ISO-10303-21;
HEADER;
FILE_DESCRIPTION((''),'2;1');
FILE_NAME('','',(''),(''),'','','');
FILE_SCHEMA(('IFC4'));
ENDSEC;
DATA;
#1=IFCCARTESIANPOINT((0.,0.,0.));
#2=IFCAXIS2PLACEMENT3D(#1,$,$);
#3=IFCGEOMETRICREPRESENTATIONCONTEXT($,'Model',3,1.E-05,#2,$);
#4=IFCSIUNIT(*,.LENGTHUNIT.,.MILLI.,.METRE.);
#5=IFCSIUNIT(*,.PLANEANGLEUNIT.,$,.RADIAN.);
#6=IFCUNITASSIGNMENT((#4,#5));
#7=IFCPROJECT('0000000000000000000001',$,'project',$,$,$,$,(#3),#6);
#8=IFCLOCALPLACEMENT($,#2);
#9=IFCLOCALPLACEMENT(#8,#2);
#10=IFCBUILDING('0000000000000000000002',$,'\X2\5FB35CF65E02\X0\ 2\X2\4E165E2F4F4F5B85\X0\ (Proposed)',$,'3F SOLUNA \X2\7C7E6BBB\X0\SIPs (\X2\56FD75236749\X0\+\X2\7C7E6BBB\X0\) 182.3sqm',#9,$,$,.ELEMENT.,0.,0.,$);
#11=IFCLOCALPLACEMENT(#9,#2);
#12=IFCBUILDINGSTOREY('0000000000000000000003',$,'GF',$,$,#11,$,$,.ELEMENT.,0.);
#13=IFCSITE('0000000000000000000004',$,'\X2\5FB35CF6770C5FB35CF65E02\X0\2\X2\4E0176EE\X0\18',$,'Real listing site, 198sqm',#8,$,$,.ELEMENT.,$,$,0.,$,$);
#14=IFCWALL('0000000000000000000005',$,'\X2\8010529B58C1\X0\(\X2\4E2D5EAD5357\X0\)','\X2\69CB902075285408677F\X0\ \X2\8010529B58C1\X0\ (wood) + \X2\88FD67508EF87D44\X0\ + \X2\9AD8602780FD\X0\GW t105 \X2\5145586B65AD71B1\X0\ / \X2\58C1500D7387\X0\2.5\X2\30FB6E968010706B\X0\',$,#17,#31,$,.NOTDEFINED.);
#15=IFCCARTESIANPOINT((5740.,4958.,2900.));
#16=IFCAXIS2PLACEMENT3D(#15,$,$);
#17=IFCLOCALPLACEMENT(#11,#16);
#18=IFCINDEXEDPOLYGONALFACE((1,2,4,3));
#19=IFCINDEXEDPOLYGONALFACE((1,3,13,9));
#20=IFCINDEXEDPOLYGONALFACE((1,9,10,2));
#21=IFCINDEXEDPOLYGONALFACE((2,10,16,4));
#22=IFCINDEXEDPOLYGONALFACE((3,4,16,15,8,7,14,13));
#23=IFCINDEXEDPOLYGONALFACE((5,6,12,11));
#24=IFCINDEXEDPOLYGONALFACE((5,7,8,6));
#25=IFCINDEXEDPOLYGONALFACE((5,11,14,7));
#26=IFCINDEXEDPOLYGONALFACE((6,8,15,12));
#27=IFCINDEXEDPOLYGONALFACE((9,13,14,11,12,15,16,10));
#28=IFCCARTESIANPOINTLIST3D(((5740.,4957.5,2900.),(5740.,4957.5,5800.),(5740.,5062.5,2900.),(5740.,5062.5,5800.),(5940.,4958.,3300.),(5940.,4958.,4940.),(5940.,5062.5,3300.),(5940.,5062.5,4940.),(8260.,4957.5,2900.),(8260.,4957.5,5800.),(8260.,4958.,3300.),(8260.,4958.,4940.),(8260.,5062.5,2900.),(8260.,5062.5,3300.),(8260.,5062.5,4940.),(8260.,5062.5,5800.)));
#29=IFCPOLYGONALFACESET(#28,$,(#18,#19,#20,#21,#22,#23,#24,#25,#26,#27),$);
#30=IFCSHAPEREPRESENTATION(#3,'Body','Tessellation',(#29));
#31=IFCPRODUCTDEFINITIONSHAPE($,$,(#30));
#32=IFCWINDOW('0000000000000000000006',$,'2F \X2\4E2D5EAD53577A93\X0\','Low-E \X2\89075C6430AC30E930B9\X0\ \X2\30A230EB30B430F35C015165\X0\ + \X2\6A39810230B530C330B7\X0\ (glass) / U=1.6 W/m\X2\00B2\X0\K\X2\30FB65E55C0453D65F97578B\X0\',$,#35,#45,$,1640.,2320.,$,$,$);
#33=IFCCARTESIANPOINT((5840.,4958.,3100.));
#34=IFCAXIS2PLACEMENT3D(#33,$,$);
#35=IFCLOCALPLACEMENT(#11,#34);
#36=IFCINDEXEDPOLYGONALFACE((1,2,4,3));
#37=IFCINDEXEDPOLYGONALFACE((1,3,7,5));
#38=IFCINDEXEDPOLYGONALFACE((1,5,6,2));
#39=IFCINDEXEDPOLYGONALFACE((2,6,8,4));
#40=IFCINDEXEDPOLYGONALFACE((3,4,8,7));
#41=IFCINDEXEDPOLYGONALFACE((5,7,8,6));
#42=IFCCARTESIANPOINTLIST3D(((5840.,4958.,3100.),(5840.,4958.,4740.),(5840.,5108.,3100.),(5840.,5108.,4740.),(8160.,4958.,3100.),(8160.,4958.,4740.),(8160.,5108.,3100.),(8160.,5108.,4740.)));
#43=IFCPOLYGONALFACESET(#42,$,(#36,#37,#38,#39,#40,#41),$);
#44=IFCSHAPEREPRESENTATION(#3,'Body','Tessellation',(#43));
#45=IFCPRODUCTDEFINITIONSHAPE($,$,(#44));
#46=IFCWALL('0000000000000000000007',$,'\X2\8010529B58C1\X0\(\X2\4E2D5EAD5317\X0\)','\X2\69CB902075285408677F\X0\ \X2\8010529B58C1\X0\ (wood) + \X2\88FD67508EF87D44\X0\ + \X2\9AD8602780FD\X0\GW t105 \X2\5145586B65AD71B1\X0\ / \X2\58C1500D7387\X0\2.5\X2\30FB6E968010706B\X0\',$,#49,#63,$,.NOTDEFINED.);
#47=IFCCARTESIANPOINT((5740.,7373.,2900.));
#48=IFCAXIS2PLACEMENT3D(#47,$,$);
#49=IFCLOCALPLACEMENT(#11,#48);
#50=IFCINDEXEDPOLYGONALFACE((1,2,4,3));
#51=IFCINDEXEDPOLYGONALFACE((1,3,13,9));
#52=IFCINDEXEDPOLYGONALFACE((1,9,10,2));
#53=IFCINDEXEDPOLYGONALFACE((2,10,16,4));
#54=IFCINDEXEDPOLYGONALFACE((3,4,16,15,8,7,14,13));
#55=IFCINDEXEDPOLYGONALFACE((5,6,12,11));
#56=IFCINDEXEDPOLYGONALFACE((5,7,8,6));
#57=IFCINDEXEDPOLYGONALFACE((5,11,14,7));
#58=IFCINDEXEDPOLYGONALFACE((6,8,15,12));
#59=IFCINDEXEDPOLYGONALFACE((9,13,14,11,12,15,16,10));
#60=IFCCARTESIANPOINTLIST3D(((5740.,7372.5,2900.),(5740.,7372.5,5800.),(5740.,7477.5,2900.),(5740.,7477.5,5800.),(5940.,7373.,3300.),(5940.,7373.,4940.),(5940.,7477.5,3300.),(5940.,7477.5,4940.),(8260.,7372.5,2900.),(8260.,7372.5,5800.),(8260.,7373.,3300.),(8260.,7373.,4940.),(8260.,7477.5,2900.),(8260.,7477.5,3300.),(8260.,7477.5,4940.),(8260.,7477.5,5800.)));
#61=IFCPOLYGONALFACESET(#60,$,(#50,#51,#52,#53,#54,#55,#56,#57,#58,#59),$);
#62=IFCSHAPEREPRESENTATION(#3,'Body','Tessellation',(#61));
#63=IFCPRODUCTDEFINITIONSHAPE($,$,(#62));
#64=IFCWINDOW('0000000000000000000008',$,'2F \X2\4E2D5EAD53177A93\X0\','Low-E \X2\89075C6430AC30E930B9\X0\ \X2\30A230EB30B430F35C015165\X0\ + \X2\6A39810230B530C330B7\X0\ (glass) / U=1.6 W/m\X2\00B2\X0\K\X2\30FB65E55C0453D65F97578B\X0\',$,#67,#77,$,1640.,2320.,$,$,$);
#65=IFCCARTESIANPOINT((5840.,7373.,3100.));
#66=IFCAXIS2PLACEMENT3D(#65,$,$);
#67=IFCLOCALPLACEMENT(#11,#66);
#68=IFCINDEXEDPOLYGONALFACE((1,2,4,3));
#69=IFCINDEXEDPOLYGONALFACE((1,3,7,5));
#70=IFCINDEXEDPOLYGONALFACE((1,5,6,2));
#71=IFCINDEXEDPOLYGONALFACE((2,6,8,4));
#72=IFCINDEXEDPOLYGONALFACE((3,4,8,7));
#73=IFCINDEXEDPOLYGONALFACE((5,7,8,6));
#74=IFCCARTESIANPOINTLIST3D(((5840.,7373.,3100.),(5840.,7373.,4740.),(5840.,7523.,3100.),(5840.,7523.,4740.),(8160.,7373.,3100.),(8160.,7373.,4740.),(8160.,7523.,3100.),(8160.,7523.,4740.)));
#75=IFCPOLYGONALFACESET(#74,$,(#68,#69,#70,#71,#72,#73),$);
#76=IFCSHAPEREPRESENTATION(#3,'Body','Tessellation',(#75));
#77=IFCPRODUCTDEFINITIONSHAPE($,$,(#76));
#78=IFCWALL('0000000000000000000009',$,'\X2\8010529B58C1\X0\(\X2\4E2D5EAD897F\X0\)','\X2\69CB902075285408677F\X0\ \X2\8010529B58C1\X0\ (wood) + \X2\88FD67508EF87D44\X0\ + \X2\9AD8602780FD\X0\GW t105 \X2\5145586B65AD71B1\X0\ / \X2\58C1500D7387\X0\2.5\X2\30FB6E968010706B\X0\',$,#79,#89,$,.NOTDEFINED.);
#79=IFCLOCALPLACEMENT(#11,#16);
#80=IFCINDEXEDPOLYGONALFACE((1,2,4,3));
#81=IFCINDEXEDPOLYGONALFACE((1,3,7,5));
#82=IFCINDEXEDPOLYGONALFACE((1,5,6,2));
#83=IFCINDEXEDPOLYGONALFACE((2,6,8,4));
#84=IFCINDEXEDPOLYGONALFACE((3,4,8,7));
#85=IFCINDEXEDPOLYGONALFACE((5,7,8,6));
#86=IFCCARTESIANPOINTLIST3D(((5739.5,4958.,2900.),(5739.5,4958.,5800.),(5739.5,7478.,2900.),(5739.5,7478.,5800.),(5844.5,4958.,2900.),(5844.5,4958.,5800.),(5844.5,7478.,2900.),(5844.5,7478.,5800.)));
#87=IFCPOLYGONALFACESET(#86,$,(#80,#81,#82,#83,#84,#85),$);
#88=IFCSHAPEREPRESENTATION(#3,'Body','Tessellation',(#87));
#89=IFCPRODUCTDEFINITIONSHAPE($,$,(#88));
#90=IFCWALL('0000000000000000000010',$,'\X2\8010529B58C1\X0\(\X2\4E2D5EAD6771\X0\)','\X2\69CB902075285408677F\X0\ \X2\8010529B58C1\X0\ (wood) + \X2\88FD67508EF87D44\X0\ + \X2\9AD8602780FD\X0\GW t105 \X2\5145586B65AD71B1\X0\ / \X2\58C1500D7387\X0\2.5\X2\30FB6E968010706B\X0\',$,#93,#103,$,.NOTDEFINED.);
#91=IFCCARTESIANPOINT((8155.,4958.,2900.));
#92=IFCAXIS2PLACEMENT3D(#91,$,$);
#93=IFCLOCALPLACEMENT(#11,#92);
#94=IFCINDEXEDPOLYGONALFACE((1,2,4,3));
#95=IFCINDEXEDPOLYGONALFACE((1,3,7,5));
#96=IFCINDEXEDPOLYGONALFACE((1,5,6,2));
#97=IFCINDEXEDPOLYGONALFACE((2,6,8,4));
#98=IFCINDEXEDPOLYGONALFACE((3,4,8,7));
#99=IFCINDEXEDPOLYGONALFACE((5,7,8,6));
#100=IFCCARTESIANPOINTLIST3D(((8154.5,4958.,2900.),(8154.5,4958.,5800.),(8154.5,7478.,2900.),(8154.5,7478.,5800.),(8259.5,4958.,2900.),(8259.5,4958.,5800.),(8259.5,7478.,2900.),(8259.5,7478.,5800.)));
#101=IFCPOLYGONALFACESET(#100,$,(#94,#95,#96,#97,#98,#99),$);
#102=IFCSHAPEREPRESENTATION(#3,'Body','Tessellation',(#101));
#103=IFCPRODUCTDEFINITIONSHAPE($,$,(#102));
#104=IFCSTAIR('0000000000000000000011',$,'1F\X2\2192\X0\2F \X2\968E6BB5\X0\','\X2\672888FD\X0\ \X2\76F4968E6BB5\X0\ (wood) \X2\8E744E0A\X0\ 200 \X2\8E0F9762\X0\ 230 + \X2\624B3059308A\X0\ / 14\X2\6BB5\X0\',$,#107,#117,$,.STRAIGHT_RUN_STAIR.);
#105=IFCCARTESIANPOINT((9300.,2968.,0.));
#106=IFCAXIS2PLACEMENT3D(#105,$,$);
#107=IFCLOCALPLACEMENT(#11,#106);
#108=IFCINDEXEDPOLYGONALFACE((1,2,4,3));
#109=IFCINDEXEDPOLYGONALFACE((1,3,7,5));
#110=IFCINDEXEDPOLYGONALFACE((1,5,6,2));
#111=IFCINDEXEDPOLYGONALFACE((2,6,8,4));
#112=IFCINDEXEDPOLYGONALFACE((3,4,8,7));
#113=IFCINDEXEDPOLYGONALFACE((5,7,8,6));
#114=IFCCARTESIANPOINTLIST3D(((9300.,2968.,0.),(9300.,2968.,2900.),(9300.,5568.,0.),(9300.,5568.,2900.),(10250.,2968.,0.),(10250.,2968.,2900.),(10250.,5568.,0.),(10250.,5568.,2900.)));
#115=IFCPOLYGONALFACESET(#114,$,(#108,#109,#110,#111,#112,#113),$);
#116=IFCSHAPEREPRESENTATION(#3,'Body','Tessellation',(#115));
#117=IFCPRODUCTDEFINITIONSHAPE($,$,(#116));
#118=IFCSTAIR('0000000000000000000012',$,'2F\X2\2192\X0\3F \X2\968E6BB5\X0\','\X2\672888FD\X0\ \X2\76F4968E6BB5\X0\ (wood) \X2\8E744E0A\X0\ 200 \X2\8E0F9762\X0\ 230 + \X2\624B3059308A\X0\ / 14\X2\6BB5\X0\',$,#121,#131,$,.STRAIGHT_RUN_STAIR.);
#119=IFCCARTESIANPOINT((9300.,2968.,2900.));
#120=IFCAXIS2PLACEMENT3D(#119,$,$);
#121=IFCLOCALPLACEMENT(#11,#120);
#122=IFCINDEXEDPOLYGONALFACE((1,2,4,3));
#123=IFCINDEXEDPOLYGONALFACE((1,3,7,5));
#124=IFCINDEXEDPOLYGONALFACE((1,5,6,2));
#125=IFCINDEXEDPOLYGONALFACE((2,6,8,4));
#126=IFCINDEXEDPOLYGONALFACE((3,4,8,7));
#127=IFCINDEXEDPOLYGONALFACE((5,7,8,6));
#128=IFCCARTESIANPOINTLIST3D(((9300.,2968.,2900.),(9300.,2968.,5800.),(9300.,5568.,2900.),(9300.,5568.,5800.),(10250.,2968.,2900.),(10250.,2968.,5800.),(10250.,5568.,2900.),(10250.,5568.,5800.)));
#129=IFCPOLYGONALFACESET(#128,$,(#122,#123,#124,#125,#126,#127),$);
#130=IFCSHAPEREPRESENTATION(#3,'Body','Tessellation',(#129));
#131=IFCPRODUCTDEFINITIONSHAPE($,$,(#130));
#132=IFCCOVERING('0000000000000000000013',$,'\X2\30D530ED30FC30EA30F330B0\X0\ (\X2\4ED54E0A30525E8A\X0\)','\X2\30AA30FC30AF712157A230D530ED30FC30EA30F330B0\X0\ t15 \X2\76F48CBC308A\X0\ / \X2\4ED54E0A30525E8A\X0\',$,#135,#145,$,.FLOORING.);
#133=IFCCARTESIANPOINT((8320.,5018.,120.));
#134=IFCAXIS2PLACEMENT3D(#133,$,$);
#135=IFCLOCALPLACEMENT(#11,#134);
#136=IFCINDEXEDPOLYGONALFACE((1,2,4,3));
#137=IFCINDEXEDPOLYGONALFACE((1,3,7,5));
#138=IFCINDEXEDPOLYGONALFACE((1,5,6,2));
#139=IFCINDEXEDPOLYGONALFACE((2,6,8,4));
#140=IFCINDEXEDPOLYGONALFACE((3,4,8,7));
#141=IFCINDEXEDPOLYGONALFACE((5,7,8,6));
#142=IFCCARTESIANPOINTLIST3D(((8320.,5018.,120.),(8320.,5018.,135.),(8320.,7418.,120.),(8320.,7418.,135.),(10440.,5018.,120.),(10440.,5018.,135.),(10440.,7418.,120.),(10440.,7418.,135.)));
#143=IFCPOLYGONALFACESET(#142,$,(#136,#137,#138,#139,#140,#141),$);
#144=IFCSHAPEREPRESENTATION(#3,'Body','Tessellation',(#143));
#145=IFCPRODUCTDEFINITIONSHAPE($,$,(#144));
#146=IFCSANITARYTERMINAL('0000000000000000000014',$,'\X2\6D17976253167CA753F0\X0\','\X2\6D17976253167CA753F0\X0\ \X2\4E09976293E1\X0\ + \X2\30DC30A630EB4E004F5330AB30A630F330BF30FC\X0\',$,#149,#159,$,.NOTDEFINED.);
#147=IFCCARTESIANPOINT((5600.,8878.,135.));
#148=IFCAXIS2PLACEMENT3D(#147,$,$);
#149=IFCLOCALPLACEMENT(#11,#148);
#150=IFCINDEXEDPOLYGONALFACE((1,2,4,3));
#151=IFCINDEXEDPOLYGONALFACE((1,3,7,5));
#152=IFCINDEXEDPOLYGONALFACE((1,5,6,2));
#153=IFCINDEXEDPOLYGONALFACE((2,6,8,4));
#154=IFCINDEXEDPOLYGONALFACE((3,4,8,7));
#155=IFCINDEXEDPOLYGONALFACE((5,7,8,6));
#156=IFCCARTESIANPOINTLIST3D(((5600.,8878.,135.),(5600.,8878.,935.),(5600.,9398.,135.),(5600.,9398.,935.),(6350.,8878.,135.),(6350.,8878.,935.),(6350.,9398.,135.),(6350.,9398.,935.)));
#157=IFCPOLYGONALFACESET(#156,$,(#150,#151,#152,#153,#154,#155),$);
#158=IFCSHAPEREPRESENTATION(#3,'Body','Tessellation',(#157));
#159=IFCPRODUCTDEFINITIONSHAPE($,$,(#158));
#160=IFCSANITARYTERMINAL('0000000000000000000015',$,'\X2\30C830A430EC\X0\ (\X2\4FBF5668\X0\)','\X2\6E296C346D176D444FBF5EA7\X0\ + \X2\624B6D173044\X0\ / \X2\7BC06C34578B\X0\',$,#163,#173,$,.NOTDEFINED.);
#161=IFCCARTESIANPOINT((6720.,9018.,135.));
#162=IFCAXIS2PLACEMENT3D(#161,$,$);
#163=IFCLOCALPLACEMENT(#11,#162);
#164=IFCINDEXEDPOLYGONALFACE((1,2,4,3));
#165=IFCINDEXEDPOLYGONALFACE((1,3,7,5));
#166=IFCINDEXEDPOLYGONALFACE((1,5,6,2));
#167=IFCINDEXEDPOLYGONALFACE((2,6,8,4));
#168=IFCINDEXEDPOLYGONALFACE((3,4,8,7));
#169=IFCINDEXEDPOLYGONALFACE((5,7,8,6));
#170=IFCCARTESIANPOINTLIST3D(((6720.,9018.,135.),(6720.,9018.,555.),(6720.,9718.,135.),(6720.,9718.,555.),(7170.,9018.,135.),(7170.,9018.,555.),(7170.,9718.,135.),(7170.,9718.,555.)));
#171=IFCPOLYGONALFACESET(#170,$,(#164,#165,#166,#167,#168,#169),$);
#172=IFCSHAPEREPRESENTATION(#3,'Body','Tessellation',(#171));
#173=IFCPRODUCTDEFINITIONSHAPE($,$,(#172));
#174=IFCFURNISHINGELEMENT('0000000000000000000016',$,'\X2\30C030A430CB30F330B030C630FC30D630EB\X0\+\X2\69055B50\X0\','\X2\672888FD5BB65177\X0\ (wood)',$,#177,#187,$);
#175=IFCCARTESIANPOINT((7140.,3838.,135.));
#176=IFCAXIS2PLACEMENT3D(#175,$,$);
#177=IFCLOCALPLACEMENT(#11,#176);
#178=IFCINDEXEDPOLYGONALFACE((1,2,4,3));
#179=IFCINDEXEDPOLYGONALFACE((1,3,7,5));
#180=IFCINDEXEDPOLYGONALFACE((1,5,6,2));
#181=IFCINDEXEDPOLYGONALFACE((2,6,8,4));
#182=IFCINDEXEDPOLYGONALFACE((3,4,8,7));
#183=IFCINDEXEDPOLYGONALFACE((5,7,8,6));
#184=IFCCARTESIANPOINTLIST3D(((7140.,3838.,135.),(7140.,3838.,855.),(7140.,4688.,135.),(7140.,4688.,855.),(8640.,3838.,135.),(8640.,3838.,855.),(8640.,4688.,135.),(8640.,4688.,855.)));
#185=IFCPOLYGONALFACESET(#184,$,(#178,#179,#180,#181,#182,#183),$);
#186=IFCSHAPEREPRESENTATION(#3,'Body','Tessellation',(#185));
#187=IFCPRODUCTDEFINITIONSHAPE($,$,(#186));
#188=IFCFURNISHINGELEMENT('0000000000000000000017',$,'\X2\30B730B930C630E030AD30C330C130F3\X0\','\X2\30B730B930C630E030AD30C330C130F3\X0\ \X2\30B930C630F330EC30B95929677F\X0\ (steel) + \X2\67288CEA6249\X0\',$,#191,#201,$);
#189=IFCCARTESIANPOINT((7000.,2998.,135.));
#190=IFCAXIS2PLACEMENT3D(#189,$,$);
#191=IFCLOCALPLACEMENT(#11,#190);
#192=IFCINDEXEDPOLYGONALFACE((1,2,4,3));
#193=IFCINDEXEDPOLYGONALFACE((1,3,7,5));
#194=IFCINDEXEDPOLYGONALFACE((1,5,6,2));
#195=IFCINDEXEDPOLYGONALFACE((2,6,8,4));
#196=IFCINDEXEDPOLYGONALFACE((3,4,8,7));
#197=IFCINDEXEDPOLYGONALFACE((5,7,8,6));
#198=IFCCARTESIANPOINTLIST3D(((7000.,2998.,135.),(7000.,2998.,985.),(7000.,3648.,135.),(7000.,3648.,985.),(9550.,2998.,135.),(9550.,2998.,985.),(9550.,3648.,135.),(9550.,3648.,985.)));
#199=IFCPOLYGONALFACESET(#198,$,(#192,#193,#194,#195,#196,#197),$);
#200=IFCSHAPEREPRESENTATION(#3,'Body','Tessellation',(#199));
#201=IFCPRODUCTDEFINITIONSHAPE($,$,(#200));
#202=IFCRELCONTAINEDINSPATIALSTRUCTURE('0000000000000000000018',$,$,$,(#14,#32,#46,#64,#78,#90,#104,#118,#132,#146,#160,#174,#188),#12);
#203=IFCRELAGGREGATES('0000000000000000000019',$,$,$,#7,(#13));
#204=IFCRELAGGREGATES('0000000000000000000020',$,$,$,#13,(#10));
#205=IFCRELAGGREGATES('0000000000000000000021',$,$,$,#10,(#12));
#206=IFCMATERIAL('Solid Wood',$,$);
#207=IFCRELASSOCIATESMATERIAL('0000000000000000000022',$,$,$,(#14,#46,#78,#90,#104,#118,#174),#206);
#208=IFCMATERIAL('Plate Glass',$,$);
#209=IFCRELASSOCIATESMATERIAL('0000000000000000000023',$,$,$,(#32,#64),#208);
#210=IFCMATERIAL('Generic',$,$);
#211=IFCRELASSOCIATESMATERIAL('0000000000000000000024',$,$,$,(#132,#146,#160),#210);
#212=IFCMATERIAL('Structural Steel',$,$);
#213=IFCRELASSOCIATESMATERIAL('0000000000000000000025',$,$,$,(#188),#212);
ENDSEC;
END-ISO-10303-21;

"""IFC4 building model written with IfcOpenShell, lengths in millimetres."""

from ifc_helpers import new_model, si_unit, frame, frame_2d, origin, place, context, project, spatial, rectangle, extrude, material, element, fill, save


model = new_model("IFC4")

# Units and contexts
model_context = context("Model", 3, precision=1e-05, world=origin())
ifc_project = project(units=[si_unit("LENGTHUNIT", "METRE", prefix="MILLI"), si_unit("PLANEANGLEUNIT", "RADIAN")], contexts=[model_context])

# Site, building, storey
site_placement = place(None, origin())
site = spatial("IfcSite", under=ifc_project, at=site_placement, Name="徳島県徳島市2丁目18", ObjectType="Real listing site, 198sqm", CompositionType="ELEMENT", RefElevation=0.0)
building_placement = place(site_placement, origin())
building = spatial("IfcBuilding", under=site, at=building_placement, Name="徳島市 2世帯住宅 (Proposed)", ObjectType="3F SOLUNA 籾殻SIPs (国産杉+籾殻) 182.3sqm", CompositionType="ELEMENT", ElevationOfRefHeight=0.0, ElevationOfTerrain=0.0)
storey_placement = place(building_placement, origin())
storey = spatial("IfcBuildingStorey", under=building, at=storey_placement, Name="GF", CompositionType="ELEMENT", Elevation=0.0)

# Shared definitions
ifc_material_1 = material(Name="Solid Wood")

# Shared definitions
ifc_material_2 = material(Name="Plate Glass")

# Walls, openings, windows
wall_1_placement = place(storey_placement, frame((5740.0, 4958.0, 2900.0)))
wall_1 = element("IfcWall", 1, at=wall_1_placement, inside=storey, material=ifc_material_1, Name="耐力壁(中庭南)", Description="構造用合板 耐力壁 (wood) + 製材軸組 + 高性能GW t105 充填断熱 / 壁倍率2.5・準耐火", PredefinedType="NOTDEFINED", context=model_context, shape_type="SweptSolid", body=[
    extrude(rectangle(XDim=2520.0, YDim=105.0, at=frame_2d((1260.0, 52.0))), frame((5740.0, 4958.0, 2900.0)), (0.0, 0.0, 1.0), 2900.0),
])
opening_1_placement = place(storey_placement, frame((5840.0, 4958.0, 3100.0)))
opening_1 = element("IfcOpeningElement", 2, at=opening_1_placement, cuts=wall_1, PredefinedType="NOTDEFINED", context=model_context, shape_type="SweptSolid", body=[
    extrude(rectangle(XDim=2320.0, YDim=150.0, at=frame_2d((1160.0, 75.0))), frame((5840.0, 4958.0, 3100.0)), (0.0, 0.0, 1.0), 1640.0),
])
window_1_placement = place(storey_placement, frame((5840.0, 4958.0, 3100.0)))
window_1 = element("IfcWindow", 3, at=window_1_placement, inside=storey, material=ifc_material_2, Name="2F 中庭南窓", Description="Low-E 複層ガラス アルゴン封入 + 樹脂サッシ (glass) / U=1.6 W/m²K・日射取得型", OverallHeight=1640.0, OverallWidth=2320.0, context=model_context, shape_type="SweptSolid", body=[
    extrude(rectangle(XDim=2320.0, YDim=150.0, at=frame_2d((1160.0, 75.0))), frame((5840.0, 4958.0, 3100.0)), (0.0, 0.0, 1.0), 1640.0),
])
fill(opening_1, window_1)
wall_2_placement = place(storey_placement, frame((5740.0, 7373.0, 2900.0)))
wall_2 = element("IfcWall", 4, at=wall_2_placement, inside=storey, material=ifc_material_1, Name="耐力壁(中庭北)", Description="構造用合板 耐力壁 (wood) + 製材軸組 + 高性能GW t105 充填断熱 / 壁倍率2.5・準耐火", PredefinedType="NOTDEFINED", context=model_context, shape_type="SweptSolid", body=[
    extrude(rectangle(XDim=2520.0, YDim=105.0, at=frame_2d((1260.0, 52.0))), frame((5740.0, 7373.0, 2900.0)), (0.0, 0.0, 1.0), 2900.0),
])
opening_2_placement = place(storey_placement, frame((5840.0, 7373.0, 3100.0)))
opening_2 = element("IfcOpeningElement", 5, at=opening_2_placement, cuts=wall_2, PredefinedType="NOTDEFINED", context=model_context, shape_type="SweptSolid", body=[
    extrude(rectangle(XDim=2320.0, YDim=150.0, at=frame_2d((1160.0, 75.0))), frame((5840.0, 7373.0, 3100.0)), (0.0, 0.0, 1.0), 1640.0),
])
window_2_placement = place(storey_placement, frame((5840.0, 7373.0, 3100.0)))
window_2 = element("IfcWindow", 6, at=window_2_placement, inside=storey, material=ifc_material_2, Name="2F 中庭北窓", Description="Low-E 複層ガラス アルゴン封入 + 樹脂サッシ (glass) / U=1.6 W/m²K・日射取得型", OverallHeight=1640.0, OverallWidth=2320.0, context=model_context, shape_type="SweptSolid", body=[
    extrude(rectangle(XDim=2320.0, YDim=150.0, at=frame_2d((1160.0, 75.0))), frame((5840.0, 7373.0, 3100.0)), (0.0, 0.0, 1.0), 1640.0),
])
fill(opening_2, window_2)

# Walls
wall_3_placement = place(storey_placement, frame((5740.0, 4958.0, 2900.0)))
element("IfcWall", 7, at=wall_3_placement, inside=storey, material=ifc_material_1, Name="耐力壁(中庭西)", Description="構造用合板 耐力壁 (wood) + 製材軸組 + 高性能GW t105 充填断熱 / 壁倍率2.5・準耐火", PredefinedType="NOTDEFINED", context=model_context, shape_type="SweptSolid", body=[
    extrude(rectangle(XDim=105.0, YDim=2520.0, at=frame_2d((52.0, 1260.0))), frame((5740.0, 4958.0, 2900.0)), (0.0, 0.0, 1.0), 2900.0),
])
wall_4_placement = place(storey_placement, frame((8155.0, 4958.0, 2900.0)))
element("IfcWall", 8, at=wall_4_placement, inside=storey, material=ifc_material_1, Name="耐力壁(中庭東)", Description="構造用合板 耐力壁 (wood) + 製材軸組 + 高性能GW t105 充填断熱 / 壁倍率2.5・準耐火", PredefinedType="NOTDEFINED", context=model_context, shape_type="SweptSolid", body=[
    extrude(rectangle(XDim=105.0, YDim=2520.0, at=frame_2d((52.0, 1260.0))), frame((8155.0, 4958.0, 2900.0)), (0.0, 0.0, 1.0), 2900.0),
])

# Stairs
stair_1_placement = place(storey_placement, frame((9300.0, 2968.0, 0.0)))
element("IfcStair", 9, at=stair_1_placement, inside=storey, material=ifc_material_1, Name="1F→2F 階段", Description="木製 直階段 (wood) 蹴上 200 踏面 230 + 手すり / 14段", PredefinedType="STRAIGHT_RUN_STAIR", context=model_context, shape_type="SweptSolid", body=[
    extrude(rectangle(XDim=950.0, YDim=2600.0, at=frame_2d((475.0, 1300.0))), frame((9300.0, 2968.0, 0.0)), (0.0, 0.0, 1.0), 2900.0),
])
stair_2_placement = place(storey_placement, frame((9300.0, 2968.0, 2900.0)))
element("IfcStair", 10, at=stair_2_placement, inside=storey, material=ifc_material_1, Name="2F→3F 階段", Description="木製 直階段 (wood) 蹴上 200 踏面 230 + 手すり / 14段", PredefinedType="STRAIGHT_RUN_STAIR", context=model_context, shape_type="SweptSolid", body=[
    extrude(rectangle(XDim=950.0, YDim=2600.0, at=frame_2d((475.0, 1300.0))), frame((9300.0, 2968.0, 2900.0)), (0.0, 0.0, 1.0), 2900.0),
])

# Covering
ifc_material_3 = material(Name="Generic")
covering_placement = place(storey_placement, frame((8320.0, 5018.0, 120.0)))
element("IfcCovering", 11, at=covering_placement, inside=storey, material=ifc_material_3, Name="フローリング (仕上げ床)", Description="オーク無垢フローリング t15 直貼り / 仕上げ床", PredefinedType="FLOORING", context=model_context, shape_type="SweptSolid", body=[
    extrude(rectangle(XDim=2120.0, YDim=2400.0, at=frame_2d((1060.0, 1200.0))), frame((8320.0, 5018.0, 120.0)), (0.0, 0.0, 1.0), 15.0),
])

# Sanitary terminals
sanitary_terminal_1_placement = place(storey_placement, frame((5600.0, 8878.0, 135.0)))
element("IfcSanitaryTerminal", 12, at=sanitary_terminal_1_placement, inside=storey, material=ifc_material_3, Name="洗面化粧台", Description="洗面化粧台 三面鏡 + ボウル一体カウンター", PredefinedType="NOTDEFINED", context=model_context, shape_type="SweptSolid", body=[
    extrude(rectangle(XDim=750.0, YDim=520.0, at=frame_2d((375.0, 260.0))), frame((5600.0, 8878.0, 135.0)), (0.0, 0.0, 1.0), 800.0),
])
sanitary_terminal_2_placement = place(storey_placement, frame((6720.0, 9018.0, 135.0)))
element("IfcSanitaryTerminal", 13, at=sanitary_terminal_2_placement, inside=storey, material=ifc_material_3, Name="トイレ (便器)", Description="温水洗浄便座 + 手洗い / 節水型", PredefinedType="NOTDEFINED", context=model_context, shape_type="SweptSolid", body=[
    extrude(rectangle(XDim=450.0, YDim=700.0, at=frame_2d((225.0, 350.0))), frame((6720.0, 9018.0, 135.0)), (0.0, 0.0, 1.0), 420.0),
])

# Furnishing elements
furnishing_1_placement = place(storey_placement, frame((7140.0, 3838.0, 135.0)))
element("IfcFurnishingElement", 14, at=furnishing_1_placement, inside=storey, material=ifc_material_1, Name="ダイニングテーブル+椅子", Description="木製家具 (wood)", context=model_context, shape_type="SweptSolid", body=[
    extrude(rectangle(XDim=1500.0, YDim=850.0, at=frame_2d((750.0, 425.0))), frame((7140.0, 3838.0, 135.0)), (0.0, 0.0, 1.0), 720.0),
])
ifc_material_4 = material(Name="Structural Steel")
furnishing_2_placement = place(storey_placement, frame((7000.0, 2998.0, 135.0)))
element("IfcFurnishingElement", 15, at=furnishing_2_placement, inside=storey, material=ifc_material_4, Name="システムキッチン", Description="システムキッチン ステンレス天板 (steel) + 木質扉", context=model_context, shape_type="SweptSolid", body=[
    extrude(rectangle(XDim=2550.0, YDim=650.0, at=frame_2d((1275.0, 325.0))), frame((7000.0, 2998.0, 135.0)), (0.0, 0.0, 1.0), 850.0),
])

save(model, "model.ifc")
